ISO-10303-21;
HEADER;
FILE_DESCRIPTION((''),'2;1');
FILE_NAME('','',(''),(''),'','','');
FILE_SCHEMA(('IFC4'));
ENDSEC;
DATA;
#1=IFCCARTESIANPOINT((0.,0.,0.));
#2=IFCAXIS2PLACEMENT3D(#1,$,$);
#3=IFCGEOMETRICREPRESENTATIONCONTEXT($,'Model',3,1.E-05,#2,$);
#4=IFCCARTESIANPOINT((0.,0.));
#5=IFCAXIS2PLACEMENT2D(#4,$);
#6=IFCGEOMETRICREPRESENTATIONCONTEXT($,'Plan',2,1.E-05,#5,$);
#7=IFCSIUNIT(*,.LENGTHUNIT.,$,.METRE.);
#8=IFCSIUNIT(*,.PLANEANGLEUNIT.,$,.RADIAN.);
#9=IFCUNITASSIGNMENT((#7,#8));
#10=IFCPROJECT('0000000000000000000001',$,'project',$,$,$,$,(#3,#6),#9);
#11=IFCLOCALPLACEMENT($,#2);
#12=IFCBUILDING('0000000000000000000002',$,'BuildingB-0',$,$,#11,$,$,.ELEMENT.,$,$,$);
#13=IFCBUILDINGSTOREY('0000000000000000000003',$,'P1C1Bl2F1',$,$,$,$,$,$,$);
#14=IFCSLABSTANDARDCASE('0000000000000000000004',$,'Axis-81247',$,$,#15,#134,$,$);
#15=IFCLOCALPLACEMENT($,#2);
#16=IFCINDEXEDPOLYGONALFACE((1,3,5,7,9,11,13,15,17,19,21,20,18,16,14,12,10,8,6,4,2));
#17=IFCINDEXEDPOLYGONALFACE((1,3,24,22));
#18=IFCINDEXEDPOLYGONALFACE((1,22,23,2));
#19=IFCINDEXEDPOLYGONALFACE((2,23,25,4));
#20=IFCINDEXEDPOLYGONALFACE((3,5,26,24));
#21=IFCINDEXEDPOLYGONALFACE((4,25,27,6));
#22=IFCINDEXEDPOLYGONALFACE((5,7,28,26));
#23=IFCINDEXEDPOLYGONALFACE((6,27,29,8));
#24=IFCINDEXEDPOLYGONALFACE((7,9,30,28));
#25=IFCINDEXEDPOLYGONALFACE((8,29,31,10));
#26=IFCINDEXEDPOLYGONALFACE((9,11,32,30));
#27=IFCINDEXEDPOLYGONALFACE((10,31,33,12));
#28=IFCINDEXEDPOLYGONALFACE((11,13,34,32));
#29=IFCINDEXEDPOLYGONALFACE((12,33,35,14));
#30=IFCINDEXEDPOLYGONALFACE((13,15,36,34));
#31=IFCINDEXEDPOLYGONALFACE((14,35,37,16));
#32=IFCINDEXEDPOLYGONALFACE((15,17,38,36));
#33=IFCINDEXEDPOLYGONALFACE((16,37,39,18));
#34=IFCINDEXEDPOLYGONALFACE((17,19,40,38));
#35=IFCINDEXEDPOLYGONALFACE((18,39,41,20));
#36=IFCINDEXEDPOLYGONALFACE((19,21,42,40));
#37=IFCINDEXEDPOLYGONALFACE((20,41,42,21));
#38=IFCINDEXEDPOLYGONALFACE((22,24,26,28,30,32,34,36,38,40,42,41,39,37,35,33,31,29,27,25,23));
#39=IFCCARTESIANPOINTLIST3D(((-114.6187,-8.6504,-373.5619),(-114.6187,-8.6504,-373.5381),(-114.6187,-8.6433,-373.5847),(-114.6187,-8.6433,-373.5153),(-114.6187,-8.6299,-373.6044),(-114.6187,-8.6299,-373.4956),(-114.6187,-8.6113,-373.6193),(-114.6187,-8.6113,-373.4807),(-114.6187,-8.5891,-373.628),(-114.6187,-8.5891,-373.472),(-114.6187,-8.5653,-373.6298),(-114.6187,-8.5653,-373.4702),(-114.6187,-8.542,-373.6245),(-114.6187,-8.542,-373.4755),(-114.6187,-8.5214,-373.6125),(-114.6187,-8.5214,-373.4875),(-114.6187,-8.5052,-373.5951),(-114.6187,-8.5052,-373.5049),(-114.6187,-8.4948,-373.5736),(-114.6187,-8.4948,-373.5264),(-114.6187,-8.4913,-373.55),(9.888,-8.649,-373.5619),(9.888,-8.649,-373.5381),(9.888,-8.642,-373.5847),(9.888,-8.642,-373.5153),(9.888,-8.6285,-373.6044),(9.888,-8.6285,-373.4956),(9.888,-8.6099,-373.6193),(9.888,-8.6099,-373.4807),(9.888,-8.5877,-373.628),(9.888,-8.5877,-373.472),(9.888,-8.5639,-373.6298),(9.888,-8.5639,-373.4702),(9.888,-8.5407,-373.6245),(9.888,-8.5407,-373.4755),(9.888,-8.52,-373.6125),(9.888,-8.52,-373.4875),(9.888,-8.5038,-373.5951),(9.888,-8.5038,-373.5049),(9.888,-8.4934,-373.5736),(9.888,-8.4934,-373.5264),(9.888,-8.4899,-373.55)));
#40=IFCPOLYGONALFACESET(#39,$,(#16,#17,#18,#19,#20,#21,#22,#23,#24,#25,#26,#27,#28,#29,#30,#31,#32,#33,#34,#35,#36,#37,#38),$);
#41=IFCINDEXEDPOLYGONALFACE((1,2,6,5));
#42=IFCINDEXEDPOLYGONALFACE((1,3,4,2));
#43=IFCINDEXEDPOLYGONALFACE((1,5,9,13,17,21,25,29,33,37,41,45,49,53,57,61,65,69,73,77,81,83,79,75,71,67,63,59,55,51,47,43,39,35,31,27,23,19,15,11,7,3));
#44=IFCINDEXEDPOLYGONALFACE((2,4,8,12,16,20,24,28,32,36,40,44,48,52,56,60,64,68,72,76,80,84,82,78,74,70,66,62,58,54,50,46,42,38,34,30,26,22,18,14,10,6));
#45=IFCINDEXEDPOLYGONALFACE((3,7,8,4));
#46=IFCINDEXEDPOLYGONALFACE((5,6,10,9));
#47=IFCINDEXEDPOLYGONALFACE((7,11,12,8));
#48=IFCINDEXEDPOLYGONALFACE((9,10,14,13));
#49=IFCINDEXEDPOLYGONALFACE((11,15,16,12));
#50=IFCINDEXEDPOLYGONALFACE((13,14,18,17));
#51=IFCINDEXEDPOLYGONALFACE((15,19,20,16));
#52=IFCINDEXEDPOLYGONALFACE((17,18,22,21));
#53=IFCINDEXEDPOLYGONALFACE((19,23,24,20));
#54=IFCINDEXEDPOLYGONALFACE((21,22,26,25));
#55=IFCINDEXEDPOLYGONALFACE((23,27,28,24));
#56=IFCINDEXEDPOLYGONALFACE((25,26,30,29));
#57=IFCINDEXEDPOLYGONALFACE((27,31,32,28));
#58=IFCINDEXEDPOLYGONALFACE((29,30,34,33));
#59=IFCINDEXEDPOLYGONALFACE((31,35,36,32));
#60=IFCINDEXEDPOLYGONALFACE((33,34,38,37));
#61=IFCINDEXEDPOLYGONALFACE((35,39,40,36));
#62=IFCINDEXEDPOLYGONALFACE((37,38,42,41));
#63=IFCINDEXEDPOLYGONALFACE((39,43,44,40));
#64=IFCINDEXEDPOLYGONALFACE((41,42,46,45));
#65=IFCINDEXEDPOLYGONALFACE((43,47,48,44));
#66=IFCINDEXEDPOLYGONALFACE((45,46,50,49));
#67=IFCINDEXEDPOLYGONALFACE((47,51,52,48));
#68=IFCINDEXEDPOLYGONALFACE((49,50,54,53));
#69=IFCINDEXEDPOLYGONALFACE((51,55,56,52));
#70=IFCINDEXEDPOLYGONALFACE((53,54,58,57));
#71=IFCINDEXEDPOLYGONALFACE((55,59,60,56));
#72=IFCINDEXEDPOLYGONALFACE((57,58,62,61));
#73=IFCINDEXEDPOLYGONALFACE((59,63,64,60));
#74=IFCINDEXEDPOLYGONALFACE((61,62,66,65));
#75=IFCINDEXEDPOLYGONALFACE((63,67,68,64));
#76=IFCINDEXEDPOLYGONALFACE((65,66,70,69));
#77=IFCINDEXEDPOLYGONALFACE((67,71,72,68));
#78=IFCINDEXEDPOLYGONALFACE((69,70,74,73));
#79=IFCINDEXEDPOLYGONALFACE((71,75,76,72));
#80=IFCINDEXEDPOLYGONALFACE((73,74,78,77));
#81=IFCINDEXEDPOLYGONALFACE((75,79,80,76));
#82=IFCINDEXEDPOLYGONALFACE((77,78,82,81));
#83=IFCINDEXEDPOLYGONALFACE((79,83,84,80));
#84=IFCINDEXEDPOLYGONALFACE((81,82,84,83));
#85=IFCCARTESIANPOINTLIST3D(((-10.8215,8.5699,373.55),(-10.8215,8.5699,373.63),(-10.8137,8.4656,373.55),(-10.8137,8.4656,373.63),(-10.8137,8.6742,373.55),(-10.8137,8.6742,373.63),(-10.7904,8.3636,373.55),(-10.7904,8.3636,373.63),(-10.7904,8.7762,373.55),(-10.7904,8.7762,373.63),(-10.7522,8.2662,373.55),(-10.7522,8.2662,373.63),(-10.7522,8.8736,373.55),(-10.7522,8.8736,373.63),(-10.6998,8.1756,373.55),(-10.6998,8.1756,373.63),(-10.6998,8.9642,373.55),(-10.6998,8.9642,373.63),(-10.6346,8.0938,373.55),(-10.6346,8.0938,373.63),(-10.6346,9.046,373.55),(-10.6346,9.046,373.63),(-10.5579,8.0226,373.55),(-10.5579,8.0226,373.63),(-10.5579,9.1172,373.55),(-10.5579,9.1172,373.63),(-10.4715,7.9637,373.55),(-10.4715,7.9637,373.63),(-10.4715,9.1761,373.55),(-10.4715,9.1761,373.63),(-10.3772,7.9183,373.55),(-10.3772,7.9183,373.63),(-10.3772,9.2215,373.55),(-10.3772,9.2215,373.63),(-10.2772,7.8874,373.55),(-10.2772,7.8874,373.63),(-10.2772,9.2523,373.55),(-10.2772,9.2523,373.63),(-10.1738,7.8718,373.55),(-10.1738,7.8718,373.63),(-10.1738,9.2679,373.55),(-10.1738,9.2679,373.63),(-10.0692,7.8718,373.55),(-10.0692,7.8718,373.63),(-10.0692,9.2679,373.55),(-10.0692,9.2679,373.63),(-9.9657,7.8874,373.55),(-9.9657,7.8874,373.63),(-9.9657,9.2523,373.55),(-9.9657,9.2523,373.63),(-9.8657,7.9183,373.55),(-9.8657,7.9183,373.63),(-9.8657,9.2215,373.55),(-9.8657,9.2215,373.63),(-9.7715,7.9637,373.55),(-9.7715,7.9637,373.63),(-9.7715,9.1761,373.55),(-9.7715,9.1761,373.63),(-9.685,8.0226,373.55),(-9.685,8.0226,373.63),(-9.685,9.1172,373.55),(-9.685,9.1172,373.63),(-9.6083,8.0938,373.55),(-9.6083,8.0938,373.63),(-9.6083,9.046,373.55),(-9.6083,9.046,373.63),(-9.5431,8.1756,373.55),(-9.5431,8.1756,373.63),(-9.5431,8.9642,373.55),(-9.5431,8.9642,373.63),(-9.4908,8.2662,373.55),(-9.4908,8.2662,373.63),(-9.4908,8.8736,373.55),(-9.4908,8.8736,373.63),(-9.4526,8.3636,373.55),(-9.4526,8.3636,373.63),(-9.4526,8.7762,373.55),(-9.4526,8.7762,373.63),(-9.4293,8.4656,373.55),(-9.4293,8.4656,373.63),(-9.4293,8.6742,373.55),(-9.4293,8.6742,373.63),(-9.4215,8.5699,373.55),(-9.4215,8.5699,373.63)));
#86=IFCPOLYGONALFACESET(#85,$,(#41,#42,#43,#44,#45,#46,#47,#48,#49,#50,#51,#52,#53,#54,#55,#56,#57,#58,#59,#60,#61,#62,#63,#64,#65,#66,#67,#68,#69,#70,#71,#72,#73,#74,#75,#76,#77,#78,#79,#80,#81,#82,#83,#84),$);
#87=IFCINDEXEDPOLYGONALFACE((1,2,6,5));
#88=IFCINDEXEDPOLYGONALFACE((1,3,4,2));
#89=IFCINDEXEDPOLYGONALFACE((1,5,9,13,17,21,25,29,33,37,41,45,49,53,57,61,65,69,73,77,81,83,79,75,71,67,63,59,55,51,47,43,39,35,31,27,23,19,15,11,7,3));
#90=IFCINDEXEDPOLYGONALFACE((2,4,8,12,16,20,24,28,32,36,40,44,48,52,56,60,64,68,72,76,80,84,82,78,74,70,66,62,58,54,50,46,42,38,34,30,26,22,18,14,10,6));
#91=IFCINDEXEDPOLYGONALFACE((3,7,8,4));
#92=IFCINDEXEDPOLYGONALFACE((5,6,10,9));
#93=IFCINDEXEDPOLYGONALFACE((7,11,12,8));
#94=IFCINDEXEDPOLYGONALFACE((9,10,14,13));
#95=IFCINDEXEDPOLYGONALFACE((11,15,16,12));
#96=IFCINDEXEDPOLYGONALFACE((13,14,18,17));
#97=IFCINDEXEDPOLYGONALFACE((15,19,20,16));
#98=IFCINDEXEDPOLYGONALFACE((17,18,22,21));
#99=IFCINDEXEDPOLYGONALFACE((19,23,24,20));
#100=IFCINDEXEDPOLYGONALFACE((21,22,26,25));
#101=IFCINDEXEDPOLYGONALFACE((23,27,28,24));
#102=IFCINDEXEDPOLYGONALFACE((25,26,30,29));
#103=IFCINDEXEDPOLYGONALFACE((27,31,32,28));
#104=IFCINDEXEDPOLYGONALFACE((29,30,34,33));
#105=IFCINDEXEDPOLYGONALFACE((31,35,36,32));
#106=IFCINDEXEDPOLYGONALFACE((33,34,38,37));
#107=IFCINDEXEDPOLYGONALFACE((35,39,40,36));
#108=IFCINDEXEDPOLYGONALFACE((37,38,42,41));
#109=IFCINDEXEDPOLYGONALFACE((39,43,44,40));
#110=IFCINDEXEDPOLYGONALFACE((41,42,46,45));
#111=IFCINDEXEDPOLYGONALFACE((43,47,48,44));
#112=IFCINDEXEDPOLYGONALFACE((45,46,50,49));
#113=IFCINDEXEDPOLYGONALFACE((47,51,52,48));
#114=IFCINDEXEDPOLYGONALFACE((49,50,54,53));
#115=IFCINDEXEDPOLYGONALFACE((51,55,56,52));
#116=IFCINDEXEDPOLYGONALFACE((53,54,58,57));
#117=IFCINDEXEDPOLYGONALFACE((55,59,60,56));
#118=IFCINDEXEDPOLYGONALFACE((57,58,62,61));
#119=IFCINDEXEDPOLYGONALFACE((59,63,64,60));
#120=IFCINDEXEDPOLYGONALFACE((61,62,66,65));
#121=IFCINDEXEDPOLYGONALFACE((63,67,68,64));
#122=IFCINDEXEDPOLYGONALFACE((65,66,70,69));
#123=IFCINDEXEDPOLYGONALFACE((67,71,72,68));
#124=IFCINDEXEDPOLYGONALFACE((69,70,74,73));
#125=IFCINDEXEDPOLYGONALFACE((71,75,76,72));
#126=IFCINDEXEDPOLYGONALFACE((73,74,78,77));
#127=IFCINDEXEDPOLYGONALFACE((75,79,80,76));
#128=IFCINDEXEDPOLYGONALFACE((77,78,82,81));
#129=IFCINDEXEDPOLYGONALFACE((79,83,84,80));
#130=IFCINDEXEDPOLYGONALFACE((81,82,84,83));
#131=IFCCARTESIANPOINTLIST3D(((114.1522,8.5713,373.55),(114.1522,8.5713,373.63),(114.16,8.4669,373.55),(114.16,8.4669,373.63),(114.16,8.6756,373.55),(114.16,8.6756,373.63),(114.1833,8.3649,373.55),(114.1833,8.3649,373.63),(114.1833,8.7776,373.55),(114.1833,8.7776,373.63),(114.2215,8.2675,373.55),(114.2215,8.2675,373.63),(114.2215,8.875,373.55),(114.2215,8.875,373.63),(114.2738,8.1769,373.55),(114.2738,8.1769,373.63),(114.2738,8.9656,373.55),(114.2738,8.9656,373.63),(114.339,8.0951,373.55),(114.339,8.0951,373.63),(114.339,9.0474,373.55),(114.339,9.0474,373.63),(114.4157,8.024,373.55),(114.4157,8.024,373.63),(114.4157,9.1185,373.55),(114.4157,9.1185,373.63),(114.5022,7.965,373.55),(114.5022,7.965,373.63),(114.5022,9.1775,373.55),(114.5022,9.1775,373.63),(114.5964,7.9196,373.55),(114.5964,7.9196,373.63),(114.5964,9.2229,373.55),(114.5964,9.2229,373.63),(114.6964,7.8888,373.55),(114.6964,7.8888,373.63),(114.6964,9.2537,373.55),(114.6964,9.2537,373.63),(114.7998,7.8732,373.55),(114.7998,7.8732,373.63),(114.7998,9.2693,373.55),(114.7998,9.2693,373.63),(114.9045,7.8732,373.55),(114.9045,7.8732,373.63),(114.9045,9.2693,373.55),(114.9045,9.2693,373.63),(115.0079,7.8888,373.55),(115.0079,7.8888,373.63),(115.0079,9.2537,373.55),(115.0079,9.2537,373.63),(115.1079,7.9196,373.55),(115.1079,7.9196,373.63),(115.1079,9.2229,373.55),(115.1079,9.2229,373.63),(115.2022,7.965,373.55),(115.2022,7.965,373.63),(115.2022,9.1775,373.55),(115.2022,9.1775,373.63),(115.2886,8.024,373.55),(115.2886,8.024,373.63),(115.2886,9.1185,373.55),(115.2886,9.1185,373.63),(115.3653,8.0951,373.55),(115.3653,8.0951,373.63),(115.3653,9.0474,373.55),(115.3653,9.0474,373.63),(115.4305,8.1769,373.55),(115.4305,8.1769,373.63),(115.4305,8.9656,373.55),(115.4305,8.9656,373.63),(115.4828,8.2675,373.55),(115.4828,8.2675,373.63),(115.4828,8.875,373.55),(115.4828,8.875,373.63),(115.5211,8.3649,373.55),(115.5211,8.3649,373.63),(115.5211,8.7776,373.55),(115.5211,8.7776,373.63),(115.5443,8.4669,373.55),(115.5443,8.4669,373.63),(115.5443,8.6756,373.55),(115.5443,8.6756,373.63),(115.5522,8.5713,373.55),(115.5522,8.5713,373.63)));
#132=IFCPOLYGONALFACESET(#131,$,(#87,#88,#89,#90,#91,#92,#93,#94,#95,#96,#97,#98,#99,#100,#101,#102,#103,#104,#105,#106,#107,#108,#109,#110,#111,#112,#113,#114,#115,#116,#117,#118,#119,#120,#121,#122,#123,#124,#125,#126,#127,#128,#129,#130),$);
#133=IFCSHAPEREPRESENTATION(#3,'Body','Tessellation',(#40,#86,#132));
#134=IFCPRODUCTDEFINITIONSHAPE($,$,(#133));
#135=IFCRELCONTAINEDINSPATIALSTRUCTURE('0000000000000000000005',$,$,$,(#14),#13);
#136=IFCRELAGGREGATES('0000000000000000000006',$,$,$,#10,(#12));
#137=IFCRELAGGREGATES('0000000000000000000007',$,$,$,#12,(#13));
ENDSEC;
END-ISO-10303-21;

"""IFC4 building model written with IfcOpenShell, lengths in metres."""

from ifc_helpers import new_model, entity, si_unit, frame, origin, origin_2d, place, context, project, spatial, circle, extrude, element, save


model = new_model("IFC4")

# Units and contexts
model_context = context("Model", 3, precision=1e-05, world=origin())
plan_context = context("Plan", 2, precision=1e-05, world=origin_2d())
ifc_project = project(units=[si_unit("LENGTHUNIT", "METRE"), si_unit("PLANEANGLEUNIT", "RADIAN")], contexts=[model_context, plan_context])

# Building, storey
building_placement = place(None, origin())
building = spatial("IfcBuilding", under=ifc_project, at=building_placement, Name="BuildingB-0", CompositionType="ELEMENT")
storey = spatial("IfcBuildingStorey", under=building, Name="P1C1Bl2F1")

# Slab
element("IfcSlabStandardCase", 1, inside=storey, Name="Axis-81247", context=model_context, shape_type="AdvancedSweptSolid", body=[
    entity("IfcSurfaceCurveSweptAreaSolid", entity("IfcCircleProfileDef", "AREA", None, None, 0.08), None, entity("IfcPolyline", [entity("IfcCartesianPoint", [-9.888, 8.5699, 373.55]), entity("IfcCartesianPoint", [114.6187, 8.5713, 373.55])]), None, None, entity("IfcPlane", entity("IfcAxis2Placement3D", entity("IfcCartesianPoint", [-9.888, 8.5699, 373.55]), entity("IfcDirection", [0.0, 0.0, 1.0]), entity("IfcDirection", [1.0, 0.0, 0.0])))),
    extrude(circle(Radius=0.7), frame((-10.1215, 8.5699, 373.55)), (0.0, 0.0, 1.0), 0.08),
    extrude(circle(Radius=0.7), frame((114.8522, 8.5713, 373.55)), (0.0, 0.0, 1.0), 0.08),
])

save(model, "model.ifc")
